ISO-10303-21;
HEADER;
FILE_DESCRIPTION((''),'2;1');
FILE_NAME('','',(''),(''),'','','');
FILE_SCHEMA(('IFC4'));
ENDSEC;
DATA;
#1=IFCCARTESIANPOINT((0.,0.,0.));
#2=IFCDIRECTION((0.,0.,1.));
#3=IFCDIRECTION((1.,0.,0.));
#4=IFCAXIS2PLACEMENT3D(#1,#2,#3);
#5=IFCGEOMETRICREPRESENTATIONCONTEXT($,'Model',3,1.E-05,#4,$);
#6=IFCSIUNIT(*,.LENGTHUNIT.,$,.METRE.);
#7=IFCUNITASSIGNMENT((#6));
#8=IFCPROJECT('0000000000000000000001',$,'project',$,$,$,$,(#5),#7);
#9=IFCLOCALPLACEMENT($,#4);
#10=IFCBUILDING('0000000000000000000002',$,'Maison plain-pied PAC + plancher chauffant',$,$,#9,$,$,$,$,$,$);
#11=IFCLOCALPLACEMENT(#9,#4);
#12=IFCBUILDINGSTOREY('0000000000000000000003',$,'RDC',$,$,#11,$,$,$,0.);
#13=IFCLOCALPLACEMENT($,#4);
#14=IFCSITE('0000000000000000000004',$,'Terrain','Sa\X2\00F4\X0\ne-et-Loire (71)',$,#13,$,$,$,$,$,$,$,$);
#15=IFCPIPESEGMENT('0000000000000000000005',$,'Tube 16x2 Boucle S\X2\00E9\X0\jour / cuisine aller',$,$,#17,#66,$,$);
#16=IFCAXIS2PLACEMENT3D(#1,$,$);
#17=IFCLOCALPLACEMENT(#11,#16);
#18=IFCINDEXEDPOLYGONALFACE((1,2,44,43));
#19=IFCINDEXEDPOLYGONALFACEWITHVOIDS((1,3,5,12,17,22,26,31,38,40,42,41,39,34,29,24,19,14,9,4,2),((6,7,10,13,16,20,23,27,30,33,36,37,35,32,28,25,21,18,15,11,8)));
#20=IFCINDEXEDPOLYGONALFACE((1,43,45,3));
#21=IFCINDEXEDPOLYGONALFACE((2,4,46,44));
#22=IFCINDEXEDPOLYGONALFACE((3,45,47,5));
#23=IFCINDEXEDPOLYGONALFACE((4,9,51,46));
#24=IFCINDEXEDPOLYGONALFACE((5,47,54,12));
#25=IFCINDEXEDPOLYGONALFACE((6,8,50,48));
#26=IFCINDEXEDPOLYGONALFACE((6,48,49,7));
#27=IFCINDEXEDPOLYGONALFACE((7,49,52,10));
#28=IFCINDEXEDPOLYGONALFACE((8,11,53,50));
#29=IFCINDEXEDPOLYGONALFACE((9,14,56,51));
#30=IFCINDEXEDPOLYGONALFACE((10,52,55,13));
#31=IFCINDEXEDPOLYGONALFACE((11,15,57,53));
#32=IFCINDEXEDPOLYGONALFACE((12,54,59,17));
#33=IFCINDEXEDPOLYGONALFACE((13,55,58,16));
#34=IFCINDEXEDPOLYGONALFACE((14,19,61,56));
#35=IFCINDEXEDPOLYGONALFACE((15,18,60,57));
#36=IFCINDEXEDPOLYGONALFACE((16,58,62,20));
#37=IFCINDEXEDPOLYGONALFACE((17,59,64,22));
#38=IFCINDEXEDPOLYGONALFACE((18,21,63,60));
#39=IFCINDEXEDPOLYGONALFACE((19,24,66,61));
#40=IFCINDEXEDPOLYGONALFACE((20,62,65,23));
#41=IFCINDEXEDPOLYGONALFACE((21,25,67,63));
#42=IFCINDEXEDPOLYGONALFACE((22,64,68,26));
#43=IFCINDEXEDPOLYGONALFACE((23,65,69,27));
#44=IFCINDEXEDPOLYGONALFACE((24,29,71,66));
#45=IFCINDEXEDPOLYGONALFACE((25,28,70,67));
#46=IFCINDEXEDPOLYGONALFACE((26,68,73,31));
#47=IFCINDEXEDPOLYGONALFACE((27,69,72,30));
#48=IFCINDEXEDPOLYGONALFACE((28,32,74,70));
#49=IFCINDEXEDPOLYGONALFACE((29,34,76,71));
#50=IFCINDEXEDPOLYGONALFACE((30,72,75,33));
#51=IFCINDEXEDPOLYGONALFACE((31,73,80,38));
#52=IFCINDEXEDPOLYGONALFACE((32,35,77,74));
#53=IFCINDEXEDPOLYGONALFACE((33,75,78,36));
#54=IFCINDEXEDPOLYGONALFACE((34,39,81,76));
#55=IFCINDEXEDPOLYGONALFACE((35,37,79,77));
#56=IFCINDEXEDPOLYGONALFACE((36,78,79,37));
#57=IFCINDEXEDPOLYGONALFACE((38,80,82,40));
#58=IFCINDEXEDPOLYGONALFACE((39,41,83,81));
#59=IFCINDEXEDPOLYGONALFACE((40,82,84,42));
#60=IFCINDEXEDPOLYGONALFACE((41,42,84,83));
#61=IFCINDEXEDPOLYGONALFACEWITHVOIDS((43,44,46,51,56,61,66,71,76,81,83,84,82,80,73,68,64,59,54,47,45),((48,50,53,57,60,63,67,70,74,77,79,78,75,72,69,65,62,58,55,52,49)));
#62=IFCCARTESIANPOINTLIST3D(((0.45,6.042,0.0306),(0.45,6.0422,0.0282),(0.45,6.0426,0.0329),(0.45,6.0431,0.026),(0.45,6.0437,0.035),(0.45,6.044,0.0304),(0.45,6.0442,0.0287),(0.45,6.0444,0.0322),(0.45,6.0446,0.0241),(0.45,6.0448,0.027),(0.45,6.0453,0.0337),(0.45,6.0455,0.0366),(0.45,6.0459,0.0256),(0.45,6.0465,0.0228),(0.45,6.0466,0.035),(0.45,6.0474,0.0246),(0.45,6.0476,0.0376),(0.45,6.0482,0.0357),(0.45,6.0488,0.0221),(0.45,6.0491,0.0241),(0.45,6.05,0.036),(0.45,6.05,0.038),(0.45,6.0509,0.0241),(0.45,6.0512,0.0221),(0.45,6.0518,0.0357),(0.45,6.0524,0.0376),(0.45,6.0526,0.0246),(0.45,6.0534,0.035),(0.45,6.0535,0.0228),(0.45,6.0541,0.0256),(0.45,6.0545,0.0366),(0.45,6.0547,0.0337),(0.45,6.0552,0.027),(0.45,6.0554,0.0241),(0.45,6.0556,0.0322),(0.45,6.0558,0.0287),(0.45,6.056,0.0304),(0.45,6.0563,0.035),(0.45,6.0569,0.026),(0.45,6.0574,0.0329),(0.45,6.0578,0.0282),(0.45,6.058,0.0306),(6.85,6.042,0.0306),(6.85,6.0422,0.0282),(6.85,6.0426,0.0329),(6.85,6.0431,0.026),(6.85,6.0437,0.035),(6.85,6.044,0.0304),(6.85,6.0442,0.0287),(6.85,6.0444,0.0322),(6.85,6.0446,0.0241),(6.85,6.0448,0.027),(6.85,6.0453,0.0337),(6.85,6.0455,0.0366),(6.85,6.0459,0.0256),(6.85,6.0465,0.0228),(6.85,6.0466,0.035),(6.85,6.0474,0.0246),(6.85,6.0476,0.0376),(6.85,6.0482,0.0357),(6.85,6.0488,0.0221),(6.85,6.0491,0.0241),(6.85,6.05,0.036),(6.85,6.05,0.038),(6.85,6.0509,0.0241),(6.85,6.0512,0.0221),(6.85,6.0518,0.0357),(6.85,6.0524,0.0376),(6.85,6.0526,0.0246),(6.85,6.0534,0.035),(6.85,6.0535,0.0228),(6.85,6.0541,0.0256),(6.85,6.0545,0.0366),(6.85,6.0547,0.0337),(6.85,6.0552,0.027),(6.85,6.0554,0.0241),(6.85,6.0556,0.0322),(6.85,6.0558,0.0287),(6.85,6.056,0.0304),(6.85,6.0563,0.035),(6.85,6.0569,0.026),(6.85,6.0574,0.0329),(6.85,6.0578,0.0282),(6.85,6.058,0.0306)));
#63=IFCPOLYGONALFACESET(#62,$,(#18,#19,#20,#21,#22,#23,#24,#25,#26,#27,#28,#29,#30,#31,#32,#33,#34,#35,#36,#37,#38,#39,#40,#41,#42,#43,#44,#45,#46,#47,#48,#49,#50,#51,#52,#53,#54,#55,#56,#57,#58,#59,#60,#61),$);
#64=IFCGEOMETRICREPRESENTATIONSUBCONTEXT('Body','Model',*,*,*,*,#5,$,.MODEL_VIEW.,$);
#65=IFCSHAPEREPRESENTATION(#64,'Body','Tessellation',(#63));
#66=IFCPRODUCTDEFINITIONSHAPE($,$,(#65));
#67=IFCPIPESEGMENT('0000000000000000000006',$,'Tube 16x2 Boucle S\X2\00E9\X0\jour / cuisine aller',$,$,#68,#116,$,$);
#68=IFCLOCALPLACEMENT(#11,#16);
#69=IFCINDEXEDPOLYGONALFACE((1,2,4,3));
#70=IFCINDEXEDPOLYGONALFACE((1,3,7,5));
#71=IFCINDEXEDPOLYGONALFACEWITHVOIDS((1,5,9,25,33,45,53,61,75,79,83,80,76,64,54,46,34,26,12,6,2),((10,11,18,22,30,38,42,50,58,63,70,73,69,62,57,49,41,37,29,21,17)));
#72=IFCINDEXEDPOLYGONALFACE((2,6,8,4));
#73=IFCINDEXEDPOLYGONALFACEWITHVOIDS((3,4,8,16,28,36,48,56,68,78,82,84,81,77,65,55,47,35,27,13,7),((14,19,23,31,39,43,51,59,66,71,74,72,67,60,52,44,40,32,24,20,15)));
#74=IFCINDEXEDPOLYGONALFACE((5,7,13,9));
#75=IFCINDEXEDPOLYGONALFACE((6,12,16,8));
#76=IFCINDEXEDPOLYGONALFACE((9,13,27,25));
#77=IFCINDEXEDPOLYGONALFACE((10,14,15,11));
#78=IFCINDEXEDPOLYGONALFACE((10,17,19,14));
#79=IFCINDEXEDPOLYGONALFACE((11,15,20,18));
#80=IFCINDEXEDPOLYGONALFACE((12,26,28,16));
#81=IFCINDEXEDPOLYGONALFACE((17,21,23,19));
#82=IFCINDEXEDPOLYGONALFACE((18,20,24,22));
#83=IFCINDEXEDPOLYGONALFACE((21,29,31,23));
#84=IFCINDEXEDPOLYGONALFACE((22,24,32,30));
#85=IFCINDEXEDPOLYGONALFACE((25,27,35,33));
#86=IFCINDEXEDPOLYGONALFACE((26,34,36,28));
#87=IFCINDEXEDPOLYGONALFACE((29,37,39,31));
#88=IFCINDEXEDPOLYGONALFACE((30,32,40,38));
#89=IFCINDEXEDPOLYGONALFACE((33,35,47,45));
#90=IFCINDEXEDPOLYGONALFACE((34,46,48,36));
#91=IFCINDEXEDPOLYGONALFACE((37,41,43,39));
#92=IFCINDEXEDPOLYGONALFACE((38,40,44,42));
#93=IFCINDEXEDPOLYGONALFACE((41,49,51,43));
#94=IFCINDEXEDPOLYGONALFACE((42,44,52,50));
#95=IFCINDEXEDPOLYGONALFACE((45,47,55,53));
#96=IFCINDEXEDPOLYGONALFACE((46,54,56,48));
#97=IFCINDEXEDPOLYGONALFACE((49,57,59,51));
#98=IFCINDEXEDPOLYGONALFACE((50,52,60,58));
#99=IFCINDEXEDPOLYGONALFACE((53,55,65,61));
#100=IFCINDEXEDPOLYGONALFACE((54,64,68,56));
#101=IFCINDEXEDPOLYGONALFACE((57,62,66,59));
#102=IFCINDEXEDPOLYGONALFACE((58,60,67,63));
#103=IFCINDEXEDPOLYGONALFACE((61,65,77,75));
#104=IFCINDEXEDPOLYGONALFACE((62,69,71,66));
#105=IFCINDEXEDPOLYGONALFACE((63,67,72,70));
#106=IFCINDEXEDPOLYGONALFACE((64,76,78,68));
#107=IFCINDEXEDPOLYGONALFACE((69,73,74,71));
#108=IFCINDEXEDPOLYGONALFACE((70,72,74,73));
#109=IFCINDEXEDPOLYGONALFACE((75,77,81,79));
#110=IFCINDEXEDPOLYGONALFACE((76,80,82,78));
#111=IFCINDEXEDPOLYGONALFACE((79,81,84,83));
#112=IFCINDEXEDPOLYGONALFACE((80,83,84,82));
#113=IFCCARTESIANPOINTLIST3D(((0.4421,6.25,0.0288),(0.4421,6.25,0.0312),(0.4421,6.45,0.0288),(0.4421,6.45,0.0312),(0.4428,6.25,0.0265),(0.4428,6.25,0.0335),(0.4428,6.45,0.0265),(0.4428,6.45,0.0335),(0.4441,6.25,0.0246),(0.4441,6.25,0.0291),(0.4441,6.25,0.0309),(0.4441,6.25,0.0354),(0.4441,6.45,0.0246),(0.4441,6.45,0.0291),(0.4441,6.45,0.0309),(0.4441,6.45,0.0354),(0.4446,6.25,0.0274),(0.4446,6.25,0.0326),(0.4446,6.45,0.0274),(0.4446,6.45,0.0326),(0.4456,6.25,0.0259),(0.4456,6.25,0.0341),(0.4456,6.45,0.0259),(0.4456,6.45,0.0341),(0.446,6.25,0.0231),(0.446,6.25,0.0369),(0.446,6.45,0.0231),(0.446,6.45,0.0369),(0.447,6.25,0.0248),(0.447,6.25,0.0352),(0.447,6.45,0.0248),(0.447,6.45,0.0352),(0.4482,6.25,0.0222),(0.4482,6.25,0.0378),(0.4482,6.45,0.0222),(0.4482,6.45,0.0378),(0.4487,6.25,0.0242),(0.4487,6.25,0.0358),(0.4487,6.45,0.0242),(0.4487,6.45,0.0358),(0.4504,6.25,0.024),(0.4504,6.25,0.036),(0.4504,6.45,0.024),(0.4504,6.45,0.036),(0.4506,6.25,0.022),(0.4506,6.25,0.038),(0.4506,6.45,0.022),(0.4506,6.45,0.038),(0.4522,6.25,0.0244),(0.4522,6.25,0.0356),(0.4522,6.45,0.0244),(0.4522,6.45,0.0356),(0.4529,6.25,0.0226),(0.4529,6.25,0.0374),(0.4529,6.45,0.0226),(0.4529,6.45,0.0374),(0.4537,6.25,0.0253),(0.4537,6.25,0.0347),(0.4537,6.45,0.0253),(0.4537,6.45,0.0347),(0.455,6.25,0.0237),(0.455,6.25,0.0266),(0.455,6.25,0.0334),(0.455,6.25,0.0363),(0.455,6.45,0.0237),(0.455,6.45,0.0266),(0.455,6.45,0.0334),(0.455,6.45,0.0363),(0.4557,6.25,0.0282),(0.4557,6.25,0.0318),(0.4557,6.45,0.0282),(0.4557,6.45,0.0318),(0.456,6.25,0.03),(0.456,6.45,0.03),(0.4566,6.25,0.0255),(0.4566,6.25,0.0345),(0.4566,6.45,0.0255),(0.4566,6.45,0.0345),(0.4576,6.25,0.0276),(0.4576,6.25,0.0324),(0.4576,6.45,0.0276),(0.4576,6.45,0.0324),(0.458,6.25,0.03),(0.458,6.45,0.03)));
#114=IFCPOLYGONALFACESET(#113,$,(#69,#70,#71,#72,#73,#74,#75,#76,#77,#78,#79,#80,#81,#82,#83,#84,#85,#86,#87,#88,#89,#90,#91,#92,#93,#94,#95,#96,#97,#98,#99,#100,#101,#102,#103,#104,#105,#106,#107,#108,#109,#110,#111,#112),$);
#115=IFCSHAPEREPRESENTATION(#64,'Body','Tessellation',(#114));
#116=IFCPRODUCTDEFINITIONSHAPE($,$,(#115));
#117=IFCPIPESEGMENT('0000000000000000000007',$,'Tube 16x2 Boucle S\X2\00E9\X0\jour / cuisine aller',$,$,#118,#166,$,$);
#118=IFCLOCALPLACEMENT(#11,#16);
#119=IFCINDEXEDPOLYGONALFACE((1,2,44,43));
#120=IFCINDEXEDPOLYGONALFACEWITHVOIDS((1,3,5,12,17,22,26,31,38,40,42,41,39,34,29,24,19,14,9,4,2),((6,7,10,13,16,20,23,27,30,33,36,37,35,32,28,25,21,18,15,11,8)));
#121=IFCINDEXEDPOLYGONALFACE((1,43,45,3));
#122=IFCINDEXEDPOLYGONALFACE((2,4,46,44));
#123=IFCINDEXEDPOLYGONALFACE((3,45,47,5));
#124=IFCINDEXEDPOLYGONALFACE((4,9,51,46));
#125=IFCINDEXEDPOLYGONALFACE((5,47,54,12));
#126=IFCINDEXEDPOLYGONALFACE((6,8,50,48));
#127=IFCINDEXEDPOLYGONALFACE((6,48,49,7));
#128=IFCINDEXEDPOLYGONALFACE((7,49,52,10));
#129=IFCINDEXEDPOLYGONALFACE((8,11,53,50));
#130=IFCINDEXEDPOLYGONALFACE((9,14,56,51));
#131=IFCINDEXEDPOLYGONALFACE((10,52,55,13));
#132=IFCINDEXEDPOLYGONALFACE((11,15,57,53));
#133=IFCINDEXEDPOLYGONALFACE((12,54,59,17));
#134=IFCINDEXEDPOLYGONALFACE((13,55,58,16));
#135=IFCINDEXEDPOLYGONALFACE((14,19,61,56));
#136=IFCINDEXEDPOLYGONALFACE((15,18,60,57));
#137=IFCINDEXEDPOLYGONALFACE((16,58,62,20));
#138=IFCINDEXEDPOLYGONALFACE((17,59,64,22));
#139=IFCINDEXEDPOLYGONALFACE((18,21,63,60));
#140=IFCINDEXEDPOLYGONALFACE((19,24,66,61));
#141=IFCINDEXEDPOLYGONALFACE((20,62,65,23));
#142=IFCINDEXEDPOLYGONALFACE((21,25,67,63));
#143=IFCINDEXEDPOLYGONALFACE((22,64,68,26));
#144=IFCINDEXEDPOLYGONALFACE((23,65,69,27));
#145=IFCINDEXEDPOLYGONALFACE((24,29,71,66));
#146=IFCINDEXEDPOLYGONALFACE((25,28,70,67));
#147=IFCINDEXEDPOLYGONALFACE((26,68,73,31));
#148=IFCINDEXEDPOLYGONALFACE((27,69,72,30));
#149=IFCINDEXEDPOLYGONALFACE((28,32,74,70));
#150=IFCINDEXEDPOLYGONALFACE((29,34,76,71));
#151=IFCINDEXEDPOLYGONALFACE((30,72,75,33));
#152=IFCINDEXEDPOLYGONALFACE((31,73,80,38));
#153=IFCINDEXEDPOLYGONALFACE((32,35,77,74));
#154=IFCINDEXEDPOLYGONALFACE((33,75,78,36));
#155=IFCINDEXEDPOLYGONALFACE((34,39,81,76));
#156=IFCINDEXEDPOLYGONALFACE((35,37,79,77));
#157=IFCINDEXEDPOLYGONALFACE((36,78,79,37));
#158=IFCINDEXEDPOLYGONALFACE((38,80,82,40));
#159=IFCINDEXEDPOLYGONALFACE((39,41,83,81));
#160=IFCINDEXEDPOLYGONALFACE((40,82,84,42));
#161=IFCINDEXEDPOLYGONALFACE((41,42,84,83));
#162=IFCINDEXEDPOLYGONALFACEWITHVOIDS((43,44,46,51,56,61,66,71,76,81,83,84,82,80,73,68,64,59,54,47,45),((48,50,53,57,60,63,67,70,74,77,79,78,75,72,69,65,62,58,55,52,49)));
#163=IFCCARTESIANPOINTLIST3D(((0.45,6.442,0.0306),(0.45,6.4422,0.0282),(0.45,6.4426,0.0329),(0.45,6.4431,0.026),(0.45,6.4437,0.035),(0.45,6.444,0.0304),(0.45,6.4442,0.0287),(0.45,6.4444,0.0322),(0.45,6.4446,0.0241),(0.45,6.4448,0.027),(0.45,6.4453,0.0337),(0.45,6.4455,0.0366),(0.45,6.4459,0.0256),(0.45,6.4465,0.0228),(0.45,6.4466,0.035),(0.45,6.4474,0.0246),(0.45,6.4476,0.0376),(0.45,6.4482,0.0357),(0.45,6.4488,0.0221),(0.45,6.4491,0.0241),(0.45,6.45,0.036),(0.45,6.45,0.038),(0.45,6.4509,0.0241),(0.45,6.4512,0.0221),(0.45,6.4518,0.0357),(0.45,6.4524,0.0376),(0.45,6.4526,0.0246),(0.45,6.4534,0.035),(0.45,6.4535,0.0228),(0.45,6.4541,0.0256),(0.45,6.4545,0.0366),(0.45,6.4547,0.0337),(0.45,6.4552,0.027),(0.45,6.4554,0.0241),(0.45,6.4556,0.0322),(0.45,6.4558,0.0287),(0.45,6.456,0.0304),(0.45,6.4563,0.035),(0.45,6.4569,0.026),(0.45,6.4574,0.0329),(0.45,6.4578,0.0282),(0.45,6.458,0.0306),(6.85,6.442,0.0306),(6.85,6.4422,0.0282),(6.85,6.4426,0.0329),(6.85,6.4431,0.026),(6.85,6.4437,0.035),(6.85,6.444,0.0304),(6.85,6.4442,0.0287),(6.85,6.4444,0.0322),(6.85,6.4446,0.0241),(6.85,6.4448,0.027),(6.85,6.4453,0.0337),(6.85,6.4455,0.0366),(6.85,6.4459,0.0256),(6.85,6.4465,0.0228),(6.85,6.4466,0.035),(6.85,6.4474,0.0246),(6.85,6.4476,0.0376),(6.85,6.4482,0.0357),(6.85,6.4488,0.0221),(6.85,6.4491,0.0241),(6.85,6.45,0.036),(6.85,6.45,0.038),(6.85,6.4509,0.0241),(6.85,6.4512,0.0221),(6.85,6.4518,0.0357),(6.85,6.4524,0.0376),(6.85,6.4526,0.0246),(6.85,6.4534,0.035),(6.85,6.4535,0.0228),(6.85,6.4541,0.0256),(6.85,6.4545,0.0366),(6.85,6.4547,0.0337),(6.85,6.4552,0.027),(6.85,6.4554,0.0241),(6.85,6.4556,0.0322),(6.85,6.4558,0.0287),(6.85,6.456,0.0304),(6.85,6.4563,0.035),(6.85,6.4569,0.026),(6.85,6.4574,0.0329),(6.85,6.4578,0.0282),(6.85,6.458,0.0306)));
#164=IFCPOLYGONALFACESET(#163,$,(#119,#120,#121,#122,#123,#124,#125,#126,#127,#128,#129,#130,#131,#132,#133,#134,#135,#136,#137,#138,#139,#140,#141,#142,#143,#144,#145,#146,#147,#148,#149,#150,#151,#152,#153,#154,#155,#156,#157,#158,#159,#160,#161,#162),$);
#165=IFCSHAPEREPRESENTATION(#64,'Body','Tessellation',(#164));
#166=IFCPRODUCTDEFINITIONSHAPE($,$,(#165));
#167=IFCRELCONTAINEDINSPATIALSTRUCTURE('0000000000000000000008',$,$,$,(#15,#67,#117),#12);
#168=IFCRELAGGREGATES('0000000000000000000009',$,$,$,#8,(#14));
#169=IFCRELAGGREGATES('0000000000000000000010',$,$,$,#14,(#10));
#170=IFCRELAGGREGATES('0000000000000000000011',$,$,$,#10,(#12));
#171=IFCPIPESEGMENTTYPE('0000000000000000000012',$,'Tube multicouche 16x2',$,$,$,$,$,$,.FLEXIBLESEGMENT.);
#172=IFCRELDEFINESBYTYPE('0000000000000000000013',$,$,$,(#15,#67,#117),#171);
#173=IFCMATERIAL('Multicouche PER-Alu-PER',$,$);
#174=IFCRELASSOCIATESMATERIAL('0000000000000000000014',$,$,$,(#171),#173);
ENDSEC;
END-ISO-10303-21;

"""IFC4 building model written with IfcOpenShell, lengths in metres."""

from ifc_helpers import new_model, si_unit, frame, origin_with_axes, place, context, subcontext, project, spatial, hollow_circle, extrude, material, type_object, element, save


model = new_model("IFC4")

# Units and contexts
model_context = context("Model", 3, precision=1e-05, world=origin_with_axes())
body_context = subcontext(model_context, "Body", "Model", "MODEL_VIEW")
ifc_project = project(units=[si_unit("LENGTHUNIT", "METRE")], contexts=[model_context])

# Site, building, storey
site_placement = place(None, origin_with_axes())
site = spatial("IfcSite", under=ifc_project, at=site_placement, Name="Terrain", Description="Saône-et-Loire (71)")
building_placement = place(None, origin_with_axes())
building = spatial("IfcBuilding", under=site, at=building_placement, Name="Maison plain-pied PAC + plancher chauffant")
storey_placement = place(building_placement, origin_with_axes())
storey = spatial("IfcBuildingStorey", under=building, at=storey_placement, Name="RDC", Elevation=0.0)

# Pipe segments
ifc_material_1 = material(Name="Multicouche PER-Alu-PER")
pipe_segment_type_1 = type_object("IfcPipeSegmentType", Name="Tube multicouche 16x2", PredefinedType="FLEXIBLESEGMENT", material=ifc_material_1)
pipe_segment_1_placement = place(storey_placement, frame((0.45, 6.05, 0.03), z_axis=(1.0, 0.0, 0.0), x_axis=(0.0, 0.0, 1.0)))
element("IfcPipeSegment", 1, at=pipe_segment_1_placement, inside=storey, type_object=pipe_segment_type_1, Name="Tube 16x2 Boucle Séjour / cuisine aller", context=body_context, shape_type="SweptSolid", body=[
    extrude(hollow_circle(Radius=0.008, WallThickness=0.002), origin_with_axes(), (0.0, 0.0, 1.0), 6.4),
])
pipe_segment_2_placement = place(storey_placement, frame((0.45, 6.25, 0.03), z_axis=(0.0, 1.0, 0.0), x_axis=(1.0, 0.0, 0.0)))
element("IfcPipeSegment", 2, at=pipe_segment_2_placement, inside=storey, type_object=pipe_segment_type_1, Name="Tube 16x2 Boucle Séjour / cuisine aller", context=body_context, shape_type="SweptSolid", body=[
    extrude(hollow_circle(Radius=0.008, WallThickness=0.002), origin_with_axes(), (0.0, 0.0, 1.0), 0.2),
])
pipe_segment_3_placement = place(storey_placement, frame((0.45, 6.45, 0.03), z_axis=(1.0, 0.0, 0.0), x_axis=(0.0, 0.0, 1.0)))
element("IfcPipeSegment", 3, at=pipe_segment_3_placement, inside=storey, type_object=pipe_segment_type_1, Name="Tube 16x2 Boucle Séjour / cuisine aller", context=body_context, shape_type="SweptSolid", body=[
    extrude(hollow_circle(Radius=0.008, WallThickness=0.002), origin_with_axes(), (0.0, 0.0, 1.0), 6.4),
])

save(model, "model.ifc")
